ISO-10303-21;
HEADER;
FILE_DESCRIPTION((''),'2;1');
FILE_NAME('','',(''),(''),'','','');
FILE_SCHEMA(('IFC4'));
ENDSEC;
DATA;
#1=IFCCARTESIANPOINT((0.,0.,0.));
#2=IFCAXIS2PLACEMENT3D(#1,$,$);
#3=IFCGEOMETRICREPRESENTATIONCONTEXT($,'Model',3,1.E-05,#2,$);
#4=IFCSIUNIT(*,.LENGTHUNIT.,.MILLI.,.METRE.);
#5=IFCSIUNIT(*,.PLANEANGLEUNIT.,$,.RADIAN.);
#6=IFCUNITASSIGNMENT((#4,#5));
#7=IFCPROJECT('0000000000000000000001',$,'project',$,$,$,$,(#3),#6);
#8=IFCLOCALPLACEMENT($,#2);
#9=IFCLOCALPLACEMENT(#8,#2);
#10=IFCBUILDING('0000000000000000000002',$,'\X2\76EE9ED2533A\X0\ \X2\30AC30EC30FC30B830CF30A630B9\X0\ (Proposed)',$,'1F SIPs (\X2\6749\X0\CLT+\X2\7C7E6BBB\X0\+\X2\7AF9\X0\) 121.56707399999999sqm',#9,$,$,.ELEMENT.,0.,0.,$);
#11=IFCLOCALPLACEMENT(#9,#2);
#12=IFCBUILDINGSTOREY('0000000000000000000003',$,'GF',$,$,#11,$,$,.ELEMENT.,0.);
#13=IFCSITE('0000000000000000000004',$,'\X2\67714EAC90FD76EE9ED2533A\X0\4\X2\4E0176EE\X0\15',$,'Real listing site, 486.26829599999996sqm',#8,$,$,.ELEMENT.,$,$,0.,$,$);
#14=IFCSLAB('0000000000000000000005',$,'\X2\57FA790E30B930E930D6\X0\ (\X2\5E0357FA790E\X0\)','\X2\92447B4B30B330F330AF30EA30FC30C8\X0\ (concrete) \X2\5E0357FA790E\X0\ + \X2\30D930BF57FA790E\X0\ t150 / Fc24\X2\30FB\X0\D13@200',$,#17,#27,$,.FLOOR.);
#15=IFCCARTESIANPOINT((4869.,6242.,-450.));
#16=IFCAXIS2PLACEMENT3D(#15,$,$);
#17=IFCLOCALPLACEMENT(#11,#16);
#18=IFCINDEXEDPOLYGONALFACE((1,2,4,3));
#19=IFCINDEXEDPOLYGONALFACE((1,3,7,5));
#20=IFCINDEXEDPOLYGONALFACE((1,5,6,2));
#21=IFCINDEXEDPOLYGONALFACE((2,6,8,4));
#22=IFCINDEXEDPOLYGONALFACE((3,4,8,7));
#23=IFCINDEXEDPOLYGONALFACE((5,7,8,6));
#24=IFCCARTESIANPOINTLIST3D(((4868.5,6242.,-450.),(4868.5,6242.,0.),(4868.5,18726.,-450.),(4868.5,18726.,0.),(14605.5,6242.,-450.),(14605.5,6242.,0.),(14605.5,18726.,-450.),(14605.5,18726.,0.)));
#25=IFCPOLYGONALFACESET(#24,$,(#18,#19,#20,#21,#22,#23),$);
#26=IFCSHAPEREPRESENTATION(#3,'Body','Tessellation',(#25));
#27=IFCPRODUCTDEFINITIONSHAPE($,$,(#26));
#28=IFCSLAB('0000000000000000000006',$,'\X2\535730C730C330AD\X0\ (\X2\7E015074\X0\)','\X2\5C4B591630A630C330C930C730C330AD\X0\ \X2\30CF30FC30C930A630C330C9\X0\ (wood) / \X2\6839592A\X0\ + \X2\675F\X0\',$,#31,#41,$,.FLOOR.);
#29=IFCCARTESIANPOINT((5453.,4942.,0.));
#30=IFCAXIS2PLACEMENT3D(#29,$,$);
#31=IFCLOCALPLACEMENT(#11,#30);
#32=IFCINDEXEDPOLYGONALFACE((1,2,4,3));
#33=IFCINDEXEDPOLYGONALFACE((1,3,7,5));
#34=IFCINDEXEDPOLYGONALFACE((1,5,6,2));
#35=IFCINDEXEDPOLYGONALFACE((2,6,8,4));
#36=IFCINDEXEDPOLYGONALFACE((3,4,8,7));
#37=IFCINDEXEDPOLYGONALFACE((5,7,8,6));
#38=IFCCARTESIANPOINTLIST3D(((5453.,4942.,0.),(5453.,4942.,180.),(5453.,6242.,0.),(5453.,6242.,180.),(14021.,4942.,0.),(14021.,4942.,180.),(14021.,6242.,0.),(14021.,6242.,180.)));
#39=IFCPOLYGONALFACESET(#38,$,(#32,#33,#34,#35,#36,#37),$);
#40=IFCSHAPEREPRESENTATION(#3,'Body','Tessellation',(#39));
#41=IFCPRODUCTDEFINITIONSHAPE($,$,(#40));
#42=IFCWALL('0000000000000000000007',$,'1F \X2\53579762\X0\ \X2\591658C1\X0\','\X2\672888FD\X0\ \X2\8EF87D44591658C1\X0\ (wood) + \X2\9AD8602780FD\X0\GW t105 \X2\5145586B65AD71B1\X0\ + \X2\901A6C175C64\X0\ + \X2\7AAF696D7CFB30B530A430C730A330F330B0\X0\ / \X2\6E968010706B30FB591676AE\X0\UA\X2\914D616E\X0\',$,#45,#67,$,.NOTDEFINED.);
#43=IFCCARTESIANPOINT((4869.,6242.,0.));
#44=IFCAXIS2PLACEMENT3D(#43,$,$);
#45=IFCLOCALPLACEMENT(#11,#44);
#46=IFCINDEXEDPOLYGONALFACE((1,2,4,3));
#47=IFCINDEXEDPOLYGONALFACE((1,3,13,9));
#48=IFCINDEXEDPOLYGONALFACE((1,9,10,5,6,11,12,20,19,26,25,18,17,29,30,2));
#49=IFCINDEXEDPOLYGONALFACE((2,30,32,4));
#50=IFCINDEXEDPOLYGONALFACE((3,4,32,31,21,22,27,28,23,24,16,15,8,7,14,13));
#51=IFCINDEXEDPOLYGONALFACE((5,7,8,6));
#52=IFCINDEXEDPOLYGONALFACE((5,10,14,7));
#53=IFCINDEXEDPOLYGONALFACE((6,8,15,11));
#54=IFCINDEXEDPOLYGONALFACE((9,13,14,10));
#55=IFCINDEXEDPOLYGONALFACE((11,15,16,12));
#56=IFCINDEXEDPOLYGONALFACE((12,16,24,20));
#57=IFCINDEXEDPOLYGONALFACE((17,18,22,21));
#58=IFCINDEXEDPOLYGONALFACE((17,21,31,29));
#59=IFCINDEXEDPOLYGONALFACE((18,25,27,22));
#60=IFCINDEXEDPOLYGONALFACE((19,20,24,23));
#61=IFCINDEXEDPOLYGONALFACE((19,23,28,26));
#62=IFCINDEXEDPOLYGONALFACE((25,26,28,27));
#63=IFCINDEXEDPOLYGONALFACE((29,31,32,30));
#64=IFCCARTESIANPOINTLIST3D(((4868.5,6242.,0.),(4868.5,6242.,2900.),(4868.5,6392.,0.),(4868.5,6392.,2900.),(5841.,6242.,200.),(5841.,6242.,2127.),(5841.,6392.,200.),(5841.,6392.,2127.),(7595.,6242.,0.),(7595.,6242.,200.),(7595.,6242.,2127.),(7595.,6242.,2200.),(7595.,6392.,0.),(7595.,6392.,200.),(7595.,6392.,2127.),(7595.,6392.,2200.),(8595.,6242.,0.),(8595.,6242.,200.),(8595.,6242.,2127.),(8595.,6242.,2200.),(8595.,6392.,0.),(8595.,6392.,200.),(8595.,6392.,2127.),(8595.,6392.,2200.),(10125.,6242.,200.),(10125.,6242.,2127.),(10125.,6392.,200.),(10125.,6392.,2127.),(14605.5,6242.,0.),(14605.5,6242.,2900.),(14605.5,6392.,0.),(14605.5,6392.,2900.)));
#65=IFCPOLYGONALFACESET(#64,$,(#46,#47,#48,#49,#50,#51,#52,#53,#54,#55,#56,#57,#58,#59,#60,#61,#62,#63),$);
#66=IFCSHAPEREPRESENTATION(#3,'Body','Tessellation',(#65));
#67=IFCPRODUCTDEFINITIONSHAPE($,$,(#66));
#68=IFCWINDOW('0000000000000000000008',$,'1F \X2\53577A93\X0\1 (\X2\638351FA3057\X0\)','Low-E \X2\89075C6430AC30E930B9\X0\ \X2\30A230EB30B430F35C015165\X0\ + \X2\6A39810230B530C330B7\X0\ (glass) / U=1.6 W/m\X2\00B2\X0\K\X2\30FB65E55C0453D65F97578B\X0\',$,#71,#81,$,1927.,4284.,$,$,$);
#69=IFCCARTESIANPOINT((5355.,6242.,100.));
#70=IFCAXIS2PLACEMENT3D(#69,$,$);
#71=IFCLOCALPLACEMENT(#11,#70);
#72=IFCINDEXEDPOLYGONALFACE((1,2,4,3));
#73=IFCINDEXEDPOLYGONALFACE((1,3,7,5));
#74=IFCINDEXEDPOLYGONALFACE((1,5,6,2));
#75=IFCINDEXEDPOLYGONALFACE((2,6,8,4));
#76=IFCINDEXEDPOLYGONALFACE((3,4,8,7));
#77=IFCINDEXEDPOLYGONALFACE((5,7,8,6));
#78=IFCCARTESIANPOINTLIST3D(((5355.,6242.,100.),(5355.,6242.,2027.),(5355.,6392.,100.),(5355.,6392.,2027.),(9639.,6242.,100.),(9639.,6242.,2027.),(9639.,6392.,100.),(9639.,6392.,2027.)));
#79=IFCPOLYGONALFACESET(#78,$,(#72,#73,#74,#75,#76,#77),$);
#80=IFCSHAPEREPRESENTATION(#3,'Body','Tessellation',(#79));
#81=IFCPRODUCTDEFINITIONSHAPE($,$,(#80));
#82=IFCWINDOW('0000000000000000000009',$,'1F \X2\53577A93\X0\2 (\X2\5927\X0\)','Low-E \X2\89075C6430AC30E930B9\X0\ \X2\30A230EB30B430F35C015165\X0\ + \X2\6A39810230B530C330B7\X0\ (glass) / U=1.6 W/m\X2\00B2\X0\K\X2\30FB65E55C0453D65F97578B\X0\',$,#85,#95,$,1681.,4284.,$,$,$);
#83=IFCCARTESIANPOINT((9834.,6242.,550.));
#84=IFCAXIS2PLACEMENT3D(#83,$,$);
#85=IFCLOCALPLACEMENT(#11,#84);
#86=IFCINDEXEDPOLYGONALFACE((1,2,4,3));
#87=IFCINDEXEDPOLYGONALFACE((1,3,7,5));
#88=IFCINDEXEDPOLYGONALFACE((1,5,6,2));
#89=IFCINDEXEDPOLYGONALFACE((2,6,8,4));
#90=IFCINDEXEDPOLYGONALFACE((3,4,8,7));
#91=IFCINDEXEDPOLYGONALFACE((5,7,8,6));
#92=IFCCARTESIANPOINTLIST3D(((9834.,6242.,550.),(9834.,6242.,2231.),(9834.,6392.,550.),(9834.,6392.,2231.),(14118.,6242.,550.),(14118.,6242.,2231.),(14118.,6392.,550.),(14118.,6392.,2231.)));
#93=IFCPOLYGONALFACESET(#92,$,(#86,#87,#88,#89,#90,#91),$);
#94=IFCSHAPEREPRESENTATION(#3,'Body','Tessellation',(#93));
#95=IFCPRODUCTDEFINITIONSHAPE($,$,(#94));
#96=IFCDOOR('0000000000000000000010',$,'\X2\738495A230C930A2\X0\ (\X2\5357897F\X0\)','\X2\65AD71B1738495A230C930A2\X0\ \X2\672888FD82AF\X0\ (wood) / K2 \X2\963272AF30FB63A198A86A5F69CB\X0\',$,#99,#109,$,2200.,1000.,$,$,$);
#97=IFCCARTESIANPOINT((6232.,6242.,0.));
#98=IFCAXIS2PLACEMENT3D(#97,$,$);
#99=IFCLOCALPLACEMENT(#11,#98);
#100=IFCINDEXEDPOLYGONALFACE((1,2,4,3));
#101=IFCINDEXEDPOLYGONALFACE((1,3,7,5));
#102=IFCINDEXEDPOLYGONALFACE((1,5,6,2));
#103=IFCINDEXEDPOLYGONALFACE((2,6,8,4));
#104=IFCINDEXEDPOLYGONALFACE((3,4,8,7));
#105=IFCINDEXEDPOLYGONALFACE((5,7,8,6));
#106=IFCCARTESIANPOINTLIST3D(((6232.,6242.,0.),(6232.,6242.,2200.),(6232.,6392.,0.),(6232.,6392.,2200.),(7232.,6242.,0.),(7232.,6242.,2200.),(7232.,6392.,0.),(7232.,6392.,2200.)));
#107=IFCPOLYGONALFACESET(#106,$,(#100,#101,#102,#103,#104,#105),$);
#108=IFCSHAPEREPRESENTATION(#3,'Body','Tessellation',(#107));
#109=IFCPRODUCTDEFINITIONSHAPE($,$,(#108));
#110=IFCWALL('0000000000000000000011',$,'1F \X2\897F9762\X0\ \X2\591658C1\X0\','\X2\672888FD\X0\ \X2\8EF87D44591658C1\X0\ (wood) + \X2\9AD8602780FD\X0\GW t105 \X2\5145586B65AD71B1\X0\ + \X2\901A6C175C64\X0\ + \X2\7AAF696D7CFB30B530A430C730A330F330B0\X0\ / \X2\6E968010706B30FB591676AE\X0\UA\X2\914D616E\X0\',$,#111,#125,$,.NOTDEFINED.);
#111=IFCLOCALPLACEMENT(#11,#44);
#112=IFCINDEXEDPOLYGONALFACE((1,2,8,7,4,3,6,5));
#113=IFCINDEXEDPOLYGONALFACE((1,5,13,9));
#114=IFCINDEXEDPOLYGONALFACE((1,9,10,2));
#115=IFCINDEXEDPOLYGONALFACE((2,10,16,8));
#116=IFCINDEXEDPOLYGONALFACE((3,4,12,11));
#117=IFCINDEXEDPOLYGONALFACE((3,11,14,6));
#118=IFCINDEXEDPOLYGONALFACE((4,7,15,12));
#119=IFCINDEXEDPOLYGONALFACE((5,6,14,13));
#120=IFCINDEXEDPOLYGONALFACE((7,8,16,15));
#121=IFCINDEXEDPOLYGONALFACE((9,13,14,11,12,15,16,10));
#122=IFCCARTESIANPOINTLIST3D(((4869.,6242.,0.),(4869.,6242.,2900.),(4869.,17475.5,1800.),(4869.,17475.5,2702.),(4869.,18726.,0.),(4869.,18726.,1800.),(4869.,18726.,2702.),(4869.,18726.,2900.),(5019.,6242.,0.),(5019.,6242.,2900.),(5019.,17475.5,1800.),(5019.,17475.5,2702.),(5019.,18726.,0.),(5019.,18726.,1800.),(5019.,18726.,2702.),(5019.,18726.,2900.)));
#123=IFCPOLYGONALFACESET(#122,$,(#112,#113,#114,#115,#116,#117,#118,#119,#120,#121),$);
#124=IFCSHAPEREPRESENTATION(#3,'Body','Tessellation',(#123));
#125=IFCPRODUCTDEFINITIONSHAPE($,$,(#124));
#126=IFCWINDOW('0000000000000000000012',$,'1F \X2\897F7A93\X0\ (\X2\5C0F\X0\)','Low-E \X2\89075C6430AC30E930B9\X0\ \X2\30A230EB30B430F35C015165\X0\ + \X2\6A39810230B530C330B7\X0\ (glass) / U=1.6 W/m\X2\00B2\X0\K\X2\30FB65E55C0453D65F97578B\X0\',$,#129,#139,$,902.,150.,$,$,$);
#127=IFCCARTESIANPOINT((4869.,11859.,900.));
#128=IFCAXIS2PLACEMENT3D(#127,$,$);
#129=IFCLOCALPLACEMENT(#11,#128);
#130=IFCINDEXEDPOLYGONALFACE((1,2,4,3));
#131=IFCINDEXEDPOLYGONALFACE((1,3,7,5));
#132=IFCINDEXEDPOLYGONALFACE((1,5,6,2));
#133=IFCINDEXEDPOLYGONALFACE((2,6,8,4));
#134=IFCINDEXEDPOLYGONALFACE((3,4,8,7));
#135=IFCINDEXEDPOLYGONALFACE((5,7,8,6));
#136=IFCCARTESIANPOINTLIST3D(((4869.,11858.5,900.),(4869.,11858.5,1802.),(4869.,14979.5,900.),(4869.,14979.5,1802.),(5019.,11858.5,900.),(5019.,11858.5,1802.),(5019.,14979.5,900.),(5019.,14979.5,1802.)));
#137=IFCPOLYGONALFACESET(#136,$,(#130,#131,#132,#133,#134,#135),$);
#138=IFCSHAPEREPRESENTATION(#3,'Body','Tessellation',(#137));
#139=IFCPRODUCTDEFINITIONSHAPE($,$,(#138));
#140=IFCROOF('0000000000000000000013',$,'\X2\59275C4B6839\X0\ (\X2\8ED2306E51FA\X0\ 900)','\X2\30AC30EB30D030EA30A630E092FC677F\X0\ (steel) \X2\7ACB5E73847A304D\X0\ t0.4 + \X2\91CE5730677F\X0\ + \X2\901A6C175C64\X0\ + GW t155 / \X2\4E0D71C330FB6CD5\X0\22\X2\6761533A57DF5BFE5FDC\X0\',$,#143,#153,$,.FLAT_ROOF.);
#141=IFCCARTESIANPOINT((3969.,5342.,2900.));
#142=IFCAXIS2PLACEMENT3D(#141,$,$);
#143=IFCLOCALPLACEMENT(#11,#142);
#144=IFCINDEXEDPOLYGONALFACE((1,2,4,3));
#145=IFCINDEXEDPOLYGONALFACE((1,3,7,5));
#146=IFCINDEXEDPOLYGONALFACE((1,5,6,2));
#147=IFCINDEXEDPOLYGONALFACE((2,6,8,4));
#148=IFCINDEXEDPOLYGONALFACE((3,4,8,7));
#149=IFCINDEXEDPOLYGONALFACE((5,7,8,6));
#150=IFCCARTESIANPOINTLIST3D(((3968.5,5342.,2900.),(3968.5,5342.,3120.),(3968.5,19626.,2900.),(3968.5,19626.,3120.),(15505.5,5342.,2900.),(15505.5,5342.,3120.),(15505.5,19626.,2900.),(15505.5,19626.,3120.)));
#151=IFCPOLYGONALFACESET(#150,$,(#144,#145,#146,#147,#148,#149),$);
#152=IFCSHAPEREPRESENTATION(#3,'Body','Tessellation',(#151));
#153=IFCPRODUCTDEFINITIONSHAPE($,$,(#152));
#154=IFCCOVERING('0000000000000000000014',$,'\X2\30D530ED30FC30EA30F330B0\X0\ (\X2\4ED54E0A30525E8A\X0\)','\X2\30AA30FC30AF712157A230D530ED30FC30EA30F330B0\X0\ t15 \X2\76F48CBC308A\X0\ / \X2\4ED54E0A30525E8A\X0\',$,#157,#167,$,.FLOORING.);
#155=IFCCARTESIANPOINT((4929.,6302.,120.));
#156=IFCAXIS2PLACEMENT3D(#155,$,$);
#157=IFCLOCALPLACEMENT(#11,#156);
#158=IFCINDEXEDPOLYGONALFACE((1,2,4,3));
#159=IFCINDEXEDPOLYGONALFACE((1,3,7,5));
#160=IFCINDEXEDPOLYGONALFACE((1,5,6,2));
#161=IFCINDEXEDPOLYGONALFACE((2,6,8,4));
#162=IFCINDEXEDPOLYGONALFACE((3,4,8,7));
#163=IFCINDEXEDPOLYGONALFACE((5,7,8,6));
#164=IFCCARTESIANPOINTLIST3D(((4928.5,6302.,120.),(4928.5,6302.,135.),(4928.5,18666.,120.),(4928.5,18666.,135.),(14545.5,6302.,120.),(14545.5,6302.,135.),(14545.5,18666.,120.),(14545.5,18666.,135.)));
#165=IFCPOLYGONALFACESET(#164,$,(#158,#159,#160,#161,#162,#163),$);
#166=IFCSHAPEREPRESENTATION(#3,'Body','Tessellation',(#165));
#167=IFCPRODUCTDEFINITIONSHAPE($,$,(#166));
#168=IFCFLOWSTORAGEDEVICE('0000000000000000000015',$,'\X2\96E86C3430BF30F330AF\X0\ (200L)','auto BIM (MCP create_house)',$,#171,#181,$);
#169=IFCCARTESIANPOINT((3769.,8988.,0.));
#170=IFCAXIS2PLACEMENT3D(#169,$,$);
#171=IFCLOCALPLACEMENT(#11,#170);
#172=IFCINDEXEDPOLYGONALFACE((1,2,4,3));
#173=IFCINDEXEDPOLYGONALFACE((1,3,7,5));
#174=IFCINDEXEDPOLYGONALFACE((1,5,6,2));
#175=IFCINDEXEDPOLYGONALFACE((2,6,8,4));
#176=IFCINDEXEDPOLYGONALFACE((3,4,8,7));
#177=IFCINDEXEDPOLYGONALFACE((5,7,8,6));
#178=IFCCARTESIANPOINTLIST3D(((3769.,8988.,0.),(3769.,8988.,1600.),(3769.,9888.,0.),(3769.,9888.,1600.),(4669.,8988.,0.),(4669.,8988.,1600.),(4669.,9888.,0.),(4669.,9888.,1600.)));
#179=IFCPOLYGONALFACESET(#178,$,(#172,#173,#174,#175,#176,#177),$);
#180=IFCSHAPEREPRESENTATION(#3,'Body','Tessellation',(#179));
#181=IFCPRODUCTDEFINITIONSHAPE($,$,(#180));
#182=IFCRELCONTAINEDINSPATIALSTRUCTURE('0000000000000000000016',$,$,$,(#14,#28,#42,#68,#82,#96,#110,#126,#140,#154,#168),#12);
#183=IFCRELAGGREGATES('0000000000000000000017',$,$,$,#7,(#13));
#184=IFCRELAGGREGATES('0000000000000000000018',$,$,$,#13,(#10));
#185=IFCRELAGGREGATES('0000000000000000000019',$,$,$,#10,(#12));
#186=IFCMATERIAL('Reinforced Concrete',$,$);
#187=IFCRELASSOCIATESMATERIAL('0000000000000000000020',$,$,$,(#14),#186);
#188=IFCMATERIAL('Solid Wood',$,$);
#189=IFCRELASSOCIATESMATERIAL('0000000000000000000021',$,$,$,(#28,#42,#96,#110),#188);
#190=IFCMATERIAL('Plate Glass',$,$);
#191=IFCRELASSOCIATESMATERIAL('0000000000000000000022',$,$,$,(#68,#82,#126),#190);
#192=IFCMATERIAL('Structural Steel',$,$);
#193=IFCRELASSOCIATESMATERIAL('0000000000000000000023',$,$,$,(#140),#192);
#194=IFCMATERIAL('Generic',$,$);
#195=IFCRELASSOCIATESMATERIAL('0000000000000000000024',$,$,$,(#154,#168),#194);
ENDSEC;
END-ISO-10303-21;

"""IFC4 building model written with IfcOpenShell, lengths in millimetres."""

from ifc_helpers import new_model, si_unit, frame, frame_2d, origin, place, context, project, spatial, rectangle, extrude, material, element, fill, save


model = new_model("IFC4")

# Units and contexts
model_context = context("Model", 3, precision=1e-05, world=origin())
ifc_project = project(units=[si_unit("LENGTHUNIT", "METRE", prefix="MILLI"), si_unit("PLANEANGLEUNIT", "RADIAN")], contexts=[model_context])

# Site, building, storey
site_placement = place(None, origin())
site = spatial("IfcSite", under=ifc_project, at=site_placement, Name="東京都目黒区4丁目15", ObjectType="Real listing site, 486.26829599999996sqm", CompositionType="ELEMENT", RefElevation=0.0)
building_placement = place(site_placement, origin())
building = spatial("IfcBuilding", under=site, at=building_placement, Name="目黒区 ガレージハウス (Proposed)", ObjectType="1F SIPs (杉CLT+籾殻+竹) 121.56707399999999sqm", CompositionType="ELEMENT", ElevationOfRefHeight=0.0, ElevationOfTerrain=0.0)
storey_placement = place(building_placement, origin())
storey = spatial("IfcBuildingStorey", under=building, at=storey_placement, Name="GF", CompositionType="ELEMENT", Elevation=0.0)

# Slabs
ifc_material_1 = material(Name="Reinforced Concrete")
slab_1_placement = place(storey_placement, frame((4869.0, 6242.0, -450.0)))
element("IfcSlab", 1, at=slab_1_placement, inside=storey, material=ifc_material_1, Name="基礎スラブ (布基礎)", Description="鉄筋コンクリート (concrete) 布基礎 + ベタ基礎 t150 / Fc24・D13@200", PredefinedType="FLOOR", context=model_context, shape_type="SweptSolid", body=[
    extrude(rectangle(XDim=9737.0, YDim=12484.0, at=frame_2d((4868.0, 6242.0))), frame((4869.0, 6242.0, -450.0)), (0.0, 0.0, 1.0), 450.0),
])
ifc_material_2 = material(Name="Solid Wood")
slab_2_placement = place(storey_placement, frame((5453.0, 4942.0, 0.0)))
element("IfcSlab", 2, at=slab_2_placement, inside=storey, material=ifc_material_2, Name="南デッキ (縁側)", Description="屋外ウッドデッキ ハードウッド (wood) / 根太 + 束", PredefinedType="FLOOR", context=model_context, shape_type="SweptSolid", body=[
    extrude(rectangle(XDim=8568.0, YDim=1300.0, at=frame_2d((4284.0, 650.0))), frame((5453.0, 4942.0, 0.0)), (0.0, 0.0, 1.0), 180.0),
])

# Wall, openings, windows, door
wall_1_placement = place(storey_placement, frame((4869.0, 6242.0, 0.0)))
wall_1 = element("IfcWall", 3, at=wall_1_placement, inside=storey, material=ifc_material_2, Name="1F 南面 外壁", Description="木製 軸組外壁 (wood) + 高性能GW t105 充填断熱 + 通気層 + 窯業系サイディング / 準耐火・外皮UA配慮", PredefinedType="NOTDEFINED", context=model_context, shape_type="SweptSolid", body=[
    extrude(rectangle(XDim=9737.0, YDim=150.0, at=frame_2d((4868.0, 75.0))), frame((4869.0, 6242.0, 0.0)), (0.0, 0.0, 1.0), 2900.0),
])
opening_1_placement = place(storey_placement, frame((5355.0, 6242.0, 100.0)))
opening_1 = element("IfcOpeningElement", 4, at=opening_1_placement, cuts=wall_1, PredefinedType="NOTDEFINED", context=model_context, shape_type="SweptSolid", body=[
    extrude(rectangle(XDim=4284.0, YDim=150.0, at=frame_2d((2142.0, 75.0))), frame((5355.0, 6242.0, 100.0)), (0.0, 0.0, 1.0), 1927.0),
])
opening_2_placement = place(storey_placement, frame((9834.0, 6242.0, 550.0)))
opening_2 = element("IfcOpeningElement", 5, at=opening_2_placement, cuts=wall_1, PredefinedType="NOTDEFINED", context=model_context, shape_type="SweptSolid", body=[
    extrude(rectangle(XDim=4284.0, YDim=150.0, at=frame_2d((2142.0, 75.0))), frame((9834.0, 6242.0, 550.0)), (0.0, 0.0, 1.0), 1681.0),
])
opening_3_placement = place(storey_placement, frame((6232.0, 6242.0, 0.0)))
opening_3 = element("IfcOpeningElement", 6, at=opening_3_placement, cuts=wall_1, PredefinedType="NOTDEFINED", context=model_context, shape_type="SweptSolid", body=[
    extrude(rectangle(XDim=1000.0, YDim=150.0, at=frame_2d((500.0, 75.0))), frame((6232.0, 6242.0, 0.0)), (0.0, 0.0, 1.0), 2200.0),
])
ifc_material_3 = material(Name="Plate Glass")
window_1_placement = place(storey_placement, frame((5355.0, 6242.0, 100.0)))
window_1 = element("IfcWindow", 7, at=window_1_placement, inside=storey, material=ifc_material_3, Name="1F 南窓1 (掃出し)", Description="Low-E 複層ガラス アルゴン封入 + 樹脂サッシ (glass) / U=1.6 W/m²K・日射取得型", OverallHeight=1927.0, OverallWidth=4284.0, context=model_context, shape_type="SweptSolid", body=[
    extrude(rectangle(XDim=4284.0, YDim=150.0, at=frame_2d((2142.0, 75.0))), frame((5355.0, 6242.0, 100.0)), (0.0, 0.0, 1.0), 1927.0),
])
fill(opening_1, window_1)
window_2_placement = place(storey_placement, frame((9834.0, 6242.0, 550.0)))
window_2 = element("IfcWindow", 8, at=window_2_placement, inside=storey, material=ifc_material_3, Name="1F 南窓2 (大)", Description="Low-E 複層ガラス アルゴン封入 + 樹脂サッシ (glass) / U=1.6 W/m²K・日射取得型", OverallHeight=1681.0, OverallWidth=4284.0, context=model_context, shape_type="SweptSolid", body=[
    extrude(rectangle(XDim=4284.0, YDim=150.0, at=frame_2d((2142.0, 75.0))), frame((9834.0, 6242.0, 550.0)), (0.0, 0.0, 1.0), 1681.0),
])
fill(opening_2, window_2)
door_placement = place(storey_placement, frame((6232.0, 6242.0, 0.0)))
door = element("IfcDoor", 9, at=door_placement, inside=storey, material=ifc_material_2, Name="玄関ドア (南西)", Description="断熱玄関ドア 木製芯 (wood) / K2 防犯・採風機構", OverallHeight=2200.0, OverallWidth=1000.0, context=model_context, shape_type="SweptSolid", body=[
    extrude(rectangle(XDim=1000.0, YDim=150.0, at=frame_2d((500.0, 75.0))), frame((6232.0, 6242.0, 0.0)), (0.0, 0.0, 1.0), 2200.0),
])
fill(opening_3, door)

# Wall, opening, window
wall_2_placement = place(storey_placement, frame((4869.0, 6242.0, 0.0)))
wall_2 = element("IfcWall", 10, at=wall_2_placement, inside=storey, material=ifc_material_2, Name="1F 西面 外壁", Description="木製 軸組外壁 (wood) + 高性能GW t105 充填断熱 + 通気層 + 窯業系サイディング / 準耐火・外皮UA配慮", PredefinedType="NOTDEFINED", context=model_context, shape_type="SweptSolid", body=[
    extrude(rectangle(XDim=150.0, YDim=12484.0, at=frame_2d((75.0, 6242.0))), frame((4869.0, 6242.0, 0.0)), (0.0, 0.0, 1.0), 2900.0),
])
opening_4_placement = place(storey_placement, frame((4869.0, 11859.0, 900.0)))
opening_4 = element("IfcOpeningElement", 11, at=opening_4_placement, cuts=wall_2, PredefinedType="NOTDEFINED", context=model_context, shape_type="SweptSolid", body=[
    extrude(rectangle(XDim=150.0, YDim=3121.0, at=frame_2d((75.0, 1560.0))), frame((4869.0, 11859.0, 900.0)), (0.0, 0.0, 1.0), 902.0),
])
window_3_placement = place(storey_placement, frame((4869.0, 11859.0, 900.0)))
window_3 = element("IfcWindow", 12, at=window_3_placement, inside=storey, material=ifc_material_3, Name="1F 西窓 (小)", Description="Low-E 複層ガラス アルゴン封入 + 樹脂サッシ (glass) / U=1.6 W/m²K・日射取得型", OverallHeight=902.0, OverallWidth=150.0, context=model_context, shape_type="SweptSolid", body=[
    extrude(rectangle(XDim=150.0, YDim=3121.0, at=frame_2d((75.0, 1560.0))), frame((4869.0, 11859.0, 900.0)), (0.0, 0.0, 1.0), 902.0),
])
fill(opening_4, window_3)

# Roof
ifc_material_4 = material(Name="Structural Steel")
roof_placement = place(storey_placement, frame((3969.0, 5342.0, 2900.0)))
element("IfcRoof", 13, at=roof_placement, inside=storey, material=ifc_material_4, Name="大屋根 (軒の出 900)", Description="ガルバリウム鋼板 (steel) 立平葺き t0.4 + 野地板 + 通気層 + GW t155 / 不燃・法22条区域対応", PredefinedType="FLAT_ROOF", context=model_context, shape_type="SweptSolid", body=[
    extrude(rectangle(XDim=11537.0, YDim=14284.0, at=frame_2d((5768.0, 7142.0))), frame((3969.0, 5342.0, 2900.0)), (0.0, 0.0, 1.0), 220.0),
])

# Covering
ifc_material_5 = material(Name="Generic")
covering_placement = place(storey_placement, frame((4929.0, 6302.0, 120.0)))
element("IfcCovering", 14, at=covering_placement, inside=storey, material=ifc_material_5, Name="フローリング (仕上げ床)", Description="オーク無垢フローリング t15 直貼り / 仕上げ床", PredefinedType="FLOORING", context=model_context, shape_type="SweptSolid", body=[
    extrude(rectangle(XDim=9617.0, YDim=12364.0, at=frame_2d((4808.0, 6182.0))), frame((4929.0, 6302.0, 120.0)), (0.0, 0.0, 1.0), 15.0),
])

# Flow storage device
flow_storage_device_placement = place(storey_placement, frame((3769.0, 8988.0, 0.0)))
element("IfcFlowStorageDevice", 15, at=flow_storage_device_placement, inside=storey, material=ifc_material_5, Name="雨水タンク (200L)", Description="auto BIM (MCP create_house)", context=model_context, shape_type="SweptSolid", body=[
    extrude(rectangle(XDim=900.0, YDim=900.0, at=frame_2d((450.0, 450.0))), frame((3769.0, 8988.0, 0.0)), (0.0, 0.0, 1.0), 1600.0),
])

save(model, "model.ifc")
